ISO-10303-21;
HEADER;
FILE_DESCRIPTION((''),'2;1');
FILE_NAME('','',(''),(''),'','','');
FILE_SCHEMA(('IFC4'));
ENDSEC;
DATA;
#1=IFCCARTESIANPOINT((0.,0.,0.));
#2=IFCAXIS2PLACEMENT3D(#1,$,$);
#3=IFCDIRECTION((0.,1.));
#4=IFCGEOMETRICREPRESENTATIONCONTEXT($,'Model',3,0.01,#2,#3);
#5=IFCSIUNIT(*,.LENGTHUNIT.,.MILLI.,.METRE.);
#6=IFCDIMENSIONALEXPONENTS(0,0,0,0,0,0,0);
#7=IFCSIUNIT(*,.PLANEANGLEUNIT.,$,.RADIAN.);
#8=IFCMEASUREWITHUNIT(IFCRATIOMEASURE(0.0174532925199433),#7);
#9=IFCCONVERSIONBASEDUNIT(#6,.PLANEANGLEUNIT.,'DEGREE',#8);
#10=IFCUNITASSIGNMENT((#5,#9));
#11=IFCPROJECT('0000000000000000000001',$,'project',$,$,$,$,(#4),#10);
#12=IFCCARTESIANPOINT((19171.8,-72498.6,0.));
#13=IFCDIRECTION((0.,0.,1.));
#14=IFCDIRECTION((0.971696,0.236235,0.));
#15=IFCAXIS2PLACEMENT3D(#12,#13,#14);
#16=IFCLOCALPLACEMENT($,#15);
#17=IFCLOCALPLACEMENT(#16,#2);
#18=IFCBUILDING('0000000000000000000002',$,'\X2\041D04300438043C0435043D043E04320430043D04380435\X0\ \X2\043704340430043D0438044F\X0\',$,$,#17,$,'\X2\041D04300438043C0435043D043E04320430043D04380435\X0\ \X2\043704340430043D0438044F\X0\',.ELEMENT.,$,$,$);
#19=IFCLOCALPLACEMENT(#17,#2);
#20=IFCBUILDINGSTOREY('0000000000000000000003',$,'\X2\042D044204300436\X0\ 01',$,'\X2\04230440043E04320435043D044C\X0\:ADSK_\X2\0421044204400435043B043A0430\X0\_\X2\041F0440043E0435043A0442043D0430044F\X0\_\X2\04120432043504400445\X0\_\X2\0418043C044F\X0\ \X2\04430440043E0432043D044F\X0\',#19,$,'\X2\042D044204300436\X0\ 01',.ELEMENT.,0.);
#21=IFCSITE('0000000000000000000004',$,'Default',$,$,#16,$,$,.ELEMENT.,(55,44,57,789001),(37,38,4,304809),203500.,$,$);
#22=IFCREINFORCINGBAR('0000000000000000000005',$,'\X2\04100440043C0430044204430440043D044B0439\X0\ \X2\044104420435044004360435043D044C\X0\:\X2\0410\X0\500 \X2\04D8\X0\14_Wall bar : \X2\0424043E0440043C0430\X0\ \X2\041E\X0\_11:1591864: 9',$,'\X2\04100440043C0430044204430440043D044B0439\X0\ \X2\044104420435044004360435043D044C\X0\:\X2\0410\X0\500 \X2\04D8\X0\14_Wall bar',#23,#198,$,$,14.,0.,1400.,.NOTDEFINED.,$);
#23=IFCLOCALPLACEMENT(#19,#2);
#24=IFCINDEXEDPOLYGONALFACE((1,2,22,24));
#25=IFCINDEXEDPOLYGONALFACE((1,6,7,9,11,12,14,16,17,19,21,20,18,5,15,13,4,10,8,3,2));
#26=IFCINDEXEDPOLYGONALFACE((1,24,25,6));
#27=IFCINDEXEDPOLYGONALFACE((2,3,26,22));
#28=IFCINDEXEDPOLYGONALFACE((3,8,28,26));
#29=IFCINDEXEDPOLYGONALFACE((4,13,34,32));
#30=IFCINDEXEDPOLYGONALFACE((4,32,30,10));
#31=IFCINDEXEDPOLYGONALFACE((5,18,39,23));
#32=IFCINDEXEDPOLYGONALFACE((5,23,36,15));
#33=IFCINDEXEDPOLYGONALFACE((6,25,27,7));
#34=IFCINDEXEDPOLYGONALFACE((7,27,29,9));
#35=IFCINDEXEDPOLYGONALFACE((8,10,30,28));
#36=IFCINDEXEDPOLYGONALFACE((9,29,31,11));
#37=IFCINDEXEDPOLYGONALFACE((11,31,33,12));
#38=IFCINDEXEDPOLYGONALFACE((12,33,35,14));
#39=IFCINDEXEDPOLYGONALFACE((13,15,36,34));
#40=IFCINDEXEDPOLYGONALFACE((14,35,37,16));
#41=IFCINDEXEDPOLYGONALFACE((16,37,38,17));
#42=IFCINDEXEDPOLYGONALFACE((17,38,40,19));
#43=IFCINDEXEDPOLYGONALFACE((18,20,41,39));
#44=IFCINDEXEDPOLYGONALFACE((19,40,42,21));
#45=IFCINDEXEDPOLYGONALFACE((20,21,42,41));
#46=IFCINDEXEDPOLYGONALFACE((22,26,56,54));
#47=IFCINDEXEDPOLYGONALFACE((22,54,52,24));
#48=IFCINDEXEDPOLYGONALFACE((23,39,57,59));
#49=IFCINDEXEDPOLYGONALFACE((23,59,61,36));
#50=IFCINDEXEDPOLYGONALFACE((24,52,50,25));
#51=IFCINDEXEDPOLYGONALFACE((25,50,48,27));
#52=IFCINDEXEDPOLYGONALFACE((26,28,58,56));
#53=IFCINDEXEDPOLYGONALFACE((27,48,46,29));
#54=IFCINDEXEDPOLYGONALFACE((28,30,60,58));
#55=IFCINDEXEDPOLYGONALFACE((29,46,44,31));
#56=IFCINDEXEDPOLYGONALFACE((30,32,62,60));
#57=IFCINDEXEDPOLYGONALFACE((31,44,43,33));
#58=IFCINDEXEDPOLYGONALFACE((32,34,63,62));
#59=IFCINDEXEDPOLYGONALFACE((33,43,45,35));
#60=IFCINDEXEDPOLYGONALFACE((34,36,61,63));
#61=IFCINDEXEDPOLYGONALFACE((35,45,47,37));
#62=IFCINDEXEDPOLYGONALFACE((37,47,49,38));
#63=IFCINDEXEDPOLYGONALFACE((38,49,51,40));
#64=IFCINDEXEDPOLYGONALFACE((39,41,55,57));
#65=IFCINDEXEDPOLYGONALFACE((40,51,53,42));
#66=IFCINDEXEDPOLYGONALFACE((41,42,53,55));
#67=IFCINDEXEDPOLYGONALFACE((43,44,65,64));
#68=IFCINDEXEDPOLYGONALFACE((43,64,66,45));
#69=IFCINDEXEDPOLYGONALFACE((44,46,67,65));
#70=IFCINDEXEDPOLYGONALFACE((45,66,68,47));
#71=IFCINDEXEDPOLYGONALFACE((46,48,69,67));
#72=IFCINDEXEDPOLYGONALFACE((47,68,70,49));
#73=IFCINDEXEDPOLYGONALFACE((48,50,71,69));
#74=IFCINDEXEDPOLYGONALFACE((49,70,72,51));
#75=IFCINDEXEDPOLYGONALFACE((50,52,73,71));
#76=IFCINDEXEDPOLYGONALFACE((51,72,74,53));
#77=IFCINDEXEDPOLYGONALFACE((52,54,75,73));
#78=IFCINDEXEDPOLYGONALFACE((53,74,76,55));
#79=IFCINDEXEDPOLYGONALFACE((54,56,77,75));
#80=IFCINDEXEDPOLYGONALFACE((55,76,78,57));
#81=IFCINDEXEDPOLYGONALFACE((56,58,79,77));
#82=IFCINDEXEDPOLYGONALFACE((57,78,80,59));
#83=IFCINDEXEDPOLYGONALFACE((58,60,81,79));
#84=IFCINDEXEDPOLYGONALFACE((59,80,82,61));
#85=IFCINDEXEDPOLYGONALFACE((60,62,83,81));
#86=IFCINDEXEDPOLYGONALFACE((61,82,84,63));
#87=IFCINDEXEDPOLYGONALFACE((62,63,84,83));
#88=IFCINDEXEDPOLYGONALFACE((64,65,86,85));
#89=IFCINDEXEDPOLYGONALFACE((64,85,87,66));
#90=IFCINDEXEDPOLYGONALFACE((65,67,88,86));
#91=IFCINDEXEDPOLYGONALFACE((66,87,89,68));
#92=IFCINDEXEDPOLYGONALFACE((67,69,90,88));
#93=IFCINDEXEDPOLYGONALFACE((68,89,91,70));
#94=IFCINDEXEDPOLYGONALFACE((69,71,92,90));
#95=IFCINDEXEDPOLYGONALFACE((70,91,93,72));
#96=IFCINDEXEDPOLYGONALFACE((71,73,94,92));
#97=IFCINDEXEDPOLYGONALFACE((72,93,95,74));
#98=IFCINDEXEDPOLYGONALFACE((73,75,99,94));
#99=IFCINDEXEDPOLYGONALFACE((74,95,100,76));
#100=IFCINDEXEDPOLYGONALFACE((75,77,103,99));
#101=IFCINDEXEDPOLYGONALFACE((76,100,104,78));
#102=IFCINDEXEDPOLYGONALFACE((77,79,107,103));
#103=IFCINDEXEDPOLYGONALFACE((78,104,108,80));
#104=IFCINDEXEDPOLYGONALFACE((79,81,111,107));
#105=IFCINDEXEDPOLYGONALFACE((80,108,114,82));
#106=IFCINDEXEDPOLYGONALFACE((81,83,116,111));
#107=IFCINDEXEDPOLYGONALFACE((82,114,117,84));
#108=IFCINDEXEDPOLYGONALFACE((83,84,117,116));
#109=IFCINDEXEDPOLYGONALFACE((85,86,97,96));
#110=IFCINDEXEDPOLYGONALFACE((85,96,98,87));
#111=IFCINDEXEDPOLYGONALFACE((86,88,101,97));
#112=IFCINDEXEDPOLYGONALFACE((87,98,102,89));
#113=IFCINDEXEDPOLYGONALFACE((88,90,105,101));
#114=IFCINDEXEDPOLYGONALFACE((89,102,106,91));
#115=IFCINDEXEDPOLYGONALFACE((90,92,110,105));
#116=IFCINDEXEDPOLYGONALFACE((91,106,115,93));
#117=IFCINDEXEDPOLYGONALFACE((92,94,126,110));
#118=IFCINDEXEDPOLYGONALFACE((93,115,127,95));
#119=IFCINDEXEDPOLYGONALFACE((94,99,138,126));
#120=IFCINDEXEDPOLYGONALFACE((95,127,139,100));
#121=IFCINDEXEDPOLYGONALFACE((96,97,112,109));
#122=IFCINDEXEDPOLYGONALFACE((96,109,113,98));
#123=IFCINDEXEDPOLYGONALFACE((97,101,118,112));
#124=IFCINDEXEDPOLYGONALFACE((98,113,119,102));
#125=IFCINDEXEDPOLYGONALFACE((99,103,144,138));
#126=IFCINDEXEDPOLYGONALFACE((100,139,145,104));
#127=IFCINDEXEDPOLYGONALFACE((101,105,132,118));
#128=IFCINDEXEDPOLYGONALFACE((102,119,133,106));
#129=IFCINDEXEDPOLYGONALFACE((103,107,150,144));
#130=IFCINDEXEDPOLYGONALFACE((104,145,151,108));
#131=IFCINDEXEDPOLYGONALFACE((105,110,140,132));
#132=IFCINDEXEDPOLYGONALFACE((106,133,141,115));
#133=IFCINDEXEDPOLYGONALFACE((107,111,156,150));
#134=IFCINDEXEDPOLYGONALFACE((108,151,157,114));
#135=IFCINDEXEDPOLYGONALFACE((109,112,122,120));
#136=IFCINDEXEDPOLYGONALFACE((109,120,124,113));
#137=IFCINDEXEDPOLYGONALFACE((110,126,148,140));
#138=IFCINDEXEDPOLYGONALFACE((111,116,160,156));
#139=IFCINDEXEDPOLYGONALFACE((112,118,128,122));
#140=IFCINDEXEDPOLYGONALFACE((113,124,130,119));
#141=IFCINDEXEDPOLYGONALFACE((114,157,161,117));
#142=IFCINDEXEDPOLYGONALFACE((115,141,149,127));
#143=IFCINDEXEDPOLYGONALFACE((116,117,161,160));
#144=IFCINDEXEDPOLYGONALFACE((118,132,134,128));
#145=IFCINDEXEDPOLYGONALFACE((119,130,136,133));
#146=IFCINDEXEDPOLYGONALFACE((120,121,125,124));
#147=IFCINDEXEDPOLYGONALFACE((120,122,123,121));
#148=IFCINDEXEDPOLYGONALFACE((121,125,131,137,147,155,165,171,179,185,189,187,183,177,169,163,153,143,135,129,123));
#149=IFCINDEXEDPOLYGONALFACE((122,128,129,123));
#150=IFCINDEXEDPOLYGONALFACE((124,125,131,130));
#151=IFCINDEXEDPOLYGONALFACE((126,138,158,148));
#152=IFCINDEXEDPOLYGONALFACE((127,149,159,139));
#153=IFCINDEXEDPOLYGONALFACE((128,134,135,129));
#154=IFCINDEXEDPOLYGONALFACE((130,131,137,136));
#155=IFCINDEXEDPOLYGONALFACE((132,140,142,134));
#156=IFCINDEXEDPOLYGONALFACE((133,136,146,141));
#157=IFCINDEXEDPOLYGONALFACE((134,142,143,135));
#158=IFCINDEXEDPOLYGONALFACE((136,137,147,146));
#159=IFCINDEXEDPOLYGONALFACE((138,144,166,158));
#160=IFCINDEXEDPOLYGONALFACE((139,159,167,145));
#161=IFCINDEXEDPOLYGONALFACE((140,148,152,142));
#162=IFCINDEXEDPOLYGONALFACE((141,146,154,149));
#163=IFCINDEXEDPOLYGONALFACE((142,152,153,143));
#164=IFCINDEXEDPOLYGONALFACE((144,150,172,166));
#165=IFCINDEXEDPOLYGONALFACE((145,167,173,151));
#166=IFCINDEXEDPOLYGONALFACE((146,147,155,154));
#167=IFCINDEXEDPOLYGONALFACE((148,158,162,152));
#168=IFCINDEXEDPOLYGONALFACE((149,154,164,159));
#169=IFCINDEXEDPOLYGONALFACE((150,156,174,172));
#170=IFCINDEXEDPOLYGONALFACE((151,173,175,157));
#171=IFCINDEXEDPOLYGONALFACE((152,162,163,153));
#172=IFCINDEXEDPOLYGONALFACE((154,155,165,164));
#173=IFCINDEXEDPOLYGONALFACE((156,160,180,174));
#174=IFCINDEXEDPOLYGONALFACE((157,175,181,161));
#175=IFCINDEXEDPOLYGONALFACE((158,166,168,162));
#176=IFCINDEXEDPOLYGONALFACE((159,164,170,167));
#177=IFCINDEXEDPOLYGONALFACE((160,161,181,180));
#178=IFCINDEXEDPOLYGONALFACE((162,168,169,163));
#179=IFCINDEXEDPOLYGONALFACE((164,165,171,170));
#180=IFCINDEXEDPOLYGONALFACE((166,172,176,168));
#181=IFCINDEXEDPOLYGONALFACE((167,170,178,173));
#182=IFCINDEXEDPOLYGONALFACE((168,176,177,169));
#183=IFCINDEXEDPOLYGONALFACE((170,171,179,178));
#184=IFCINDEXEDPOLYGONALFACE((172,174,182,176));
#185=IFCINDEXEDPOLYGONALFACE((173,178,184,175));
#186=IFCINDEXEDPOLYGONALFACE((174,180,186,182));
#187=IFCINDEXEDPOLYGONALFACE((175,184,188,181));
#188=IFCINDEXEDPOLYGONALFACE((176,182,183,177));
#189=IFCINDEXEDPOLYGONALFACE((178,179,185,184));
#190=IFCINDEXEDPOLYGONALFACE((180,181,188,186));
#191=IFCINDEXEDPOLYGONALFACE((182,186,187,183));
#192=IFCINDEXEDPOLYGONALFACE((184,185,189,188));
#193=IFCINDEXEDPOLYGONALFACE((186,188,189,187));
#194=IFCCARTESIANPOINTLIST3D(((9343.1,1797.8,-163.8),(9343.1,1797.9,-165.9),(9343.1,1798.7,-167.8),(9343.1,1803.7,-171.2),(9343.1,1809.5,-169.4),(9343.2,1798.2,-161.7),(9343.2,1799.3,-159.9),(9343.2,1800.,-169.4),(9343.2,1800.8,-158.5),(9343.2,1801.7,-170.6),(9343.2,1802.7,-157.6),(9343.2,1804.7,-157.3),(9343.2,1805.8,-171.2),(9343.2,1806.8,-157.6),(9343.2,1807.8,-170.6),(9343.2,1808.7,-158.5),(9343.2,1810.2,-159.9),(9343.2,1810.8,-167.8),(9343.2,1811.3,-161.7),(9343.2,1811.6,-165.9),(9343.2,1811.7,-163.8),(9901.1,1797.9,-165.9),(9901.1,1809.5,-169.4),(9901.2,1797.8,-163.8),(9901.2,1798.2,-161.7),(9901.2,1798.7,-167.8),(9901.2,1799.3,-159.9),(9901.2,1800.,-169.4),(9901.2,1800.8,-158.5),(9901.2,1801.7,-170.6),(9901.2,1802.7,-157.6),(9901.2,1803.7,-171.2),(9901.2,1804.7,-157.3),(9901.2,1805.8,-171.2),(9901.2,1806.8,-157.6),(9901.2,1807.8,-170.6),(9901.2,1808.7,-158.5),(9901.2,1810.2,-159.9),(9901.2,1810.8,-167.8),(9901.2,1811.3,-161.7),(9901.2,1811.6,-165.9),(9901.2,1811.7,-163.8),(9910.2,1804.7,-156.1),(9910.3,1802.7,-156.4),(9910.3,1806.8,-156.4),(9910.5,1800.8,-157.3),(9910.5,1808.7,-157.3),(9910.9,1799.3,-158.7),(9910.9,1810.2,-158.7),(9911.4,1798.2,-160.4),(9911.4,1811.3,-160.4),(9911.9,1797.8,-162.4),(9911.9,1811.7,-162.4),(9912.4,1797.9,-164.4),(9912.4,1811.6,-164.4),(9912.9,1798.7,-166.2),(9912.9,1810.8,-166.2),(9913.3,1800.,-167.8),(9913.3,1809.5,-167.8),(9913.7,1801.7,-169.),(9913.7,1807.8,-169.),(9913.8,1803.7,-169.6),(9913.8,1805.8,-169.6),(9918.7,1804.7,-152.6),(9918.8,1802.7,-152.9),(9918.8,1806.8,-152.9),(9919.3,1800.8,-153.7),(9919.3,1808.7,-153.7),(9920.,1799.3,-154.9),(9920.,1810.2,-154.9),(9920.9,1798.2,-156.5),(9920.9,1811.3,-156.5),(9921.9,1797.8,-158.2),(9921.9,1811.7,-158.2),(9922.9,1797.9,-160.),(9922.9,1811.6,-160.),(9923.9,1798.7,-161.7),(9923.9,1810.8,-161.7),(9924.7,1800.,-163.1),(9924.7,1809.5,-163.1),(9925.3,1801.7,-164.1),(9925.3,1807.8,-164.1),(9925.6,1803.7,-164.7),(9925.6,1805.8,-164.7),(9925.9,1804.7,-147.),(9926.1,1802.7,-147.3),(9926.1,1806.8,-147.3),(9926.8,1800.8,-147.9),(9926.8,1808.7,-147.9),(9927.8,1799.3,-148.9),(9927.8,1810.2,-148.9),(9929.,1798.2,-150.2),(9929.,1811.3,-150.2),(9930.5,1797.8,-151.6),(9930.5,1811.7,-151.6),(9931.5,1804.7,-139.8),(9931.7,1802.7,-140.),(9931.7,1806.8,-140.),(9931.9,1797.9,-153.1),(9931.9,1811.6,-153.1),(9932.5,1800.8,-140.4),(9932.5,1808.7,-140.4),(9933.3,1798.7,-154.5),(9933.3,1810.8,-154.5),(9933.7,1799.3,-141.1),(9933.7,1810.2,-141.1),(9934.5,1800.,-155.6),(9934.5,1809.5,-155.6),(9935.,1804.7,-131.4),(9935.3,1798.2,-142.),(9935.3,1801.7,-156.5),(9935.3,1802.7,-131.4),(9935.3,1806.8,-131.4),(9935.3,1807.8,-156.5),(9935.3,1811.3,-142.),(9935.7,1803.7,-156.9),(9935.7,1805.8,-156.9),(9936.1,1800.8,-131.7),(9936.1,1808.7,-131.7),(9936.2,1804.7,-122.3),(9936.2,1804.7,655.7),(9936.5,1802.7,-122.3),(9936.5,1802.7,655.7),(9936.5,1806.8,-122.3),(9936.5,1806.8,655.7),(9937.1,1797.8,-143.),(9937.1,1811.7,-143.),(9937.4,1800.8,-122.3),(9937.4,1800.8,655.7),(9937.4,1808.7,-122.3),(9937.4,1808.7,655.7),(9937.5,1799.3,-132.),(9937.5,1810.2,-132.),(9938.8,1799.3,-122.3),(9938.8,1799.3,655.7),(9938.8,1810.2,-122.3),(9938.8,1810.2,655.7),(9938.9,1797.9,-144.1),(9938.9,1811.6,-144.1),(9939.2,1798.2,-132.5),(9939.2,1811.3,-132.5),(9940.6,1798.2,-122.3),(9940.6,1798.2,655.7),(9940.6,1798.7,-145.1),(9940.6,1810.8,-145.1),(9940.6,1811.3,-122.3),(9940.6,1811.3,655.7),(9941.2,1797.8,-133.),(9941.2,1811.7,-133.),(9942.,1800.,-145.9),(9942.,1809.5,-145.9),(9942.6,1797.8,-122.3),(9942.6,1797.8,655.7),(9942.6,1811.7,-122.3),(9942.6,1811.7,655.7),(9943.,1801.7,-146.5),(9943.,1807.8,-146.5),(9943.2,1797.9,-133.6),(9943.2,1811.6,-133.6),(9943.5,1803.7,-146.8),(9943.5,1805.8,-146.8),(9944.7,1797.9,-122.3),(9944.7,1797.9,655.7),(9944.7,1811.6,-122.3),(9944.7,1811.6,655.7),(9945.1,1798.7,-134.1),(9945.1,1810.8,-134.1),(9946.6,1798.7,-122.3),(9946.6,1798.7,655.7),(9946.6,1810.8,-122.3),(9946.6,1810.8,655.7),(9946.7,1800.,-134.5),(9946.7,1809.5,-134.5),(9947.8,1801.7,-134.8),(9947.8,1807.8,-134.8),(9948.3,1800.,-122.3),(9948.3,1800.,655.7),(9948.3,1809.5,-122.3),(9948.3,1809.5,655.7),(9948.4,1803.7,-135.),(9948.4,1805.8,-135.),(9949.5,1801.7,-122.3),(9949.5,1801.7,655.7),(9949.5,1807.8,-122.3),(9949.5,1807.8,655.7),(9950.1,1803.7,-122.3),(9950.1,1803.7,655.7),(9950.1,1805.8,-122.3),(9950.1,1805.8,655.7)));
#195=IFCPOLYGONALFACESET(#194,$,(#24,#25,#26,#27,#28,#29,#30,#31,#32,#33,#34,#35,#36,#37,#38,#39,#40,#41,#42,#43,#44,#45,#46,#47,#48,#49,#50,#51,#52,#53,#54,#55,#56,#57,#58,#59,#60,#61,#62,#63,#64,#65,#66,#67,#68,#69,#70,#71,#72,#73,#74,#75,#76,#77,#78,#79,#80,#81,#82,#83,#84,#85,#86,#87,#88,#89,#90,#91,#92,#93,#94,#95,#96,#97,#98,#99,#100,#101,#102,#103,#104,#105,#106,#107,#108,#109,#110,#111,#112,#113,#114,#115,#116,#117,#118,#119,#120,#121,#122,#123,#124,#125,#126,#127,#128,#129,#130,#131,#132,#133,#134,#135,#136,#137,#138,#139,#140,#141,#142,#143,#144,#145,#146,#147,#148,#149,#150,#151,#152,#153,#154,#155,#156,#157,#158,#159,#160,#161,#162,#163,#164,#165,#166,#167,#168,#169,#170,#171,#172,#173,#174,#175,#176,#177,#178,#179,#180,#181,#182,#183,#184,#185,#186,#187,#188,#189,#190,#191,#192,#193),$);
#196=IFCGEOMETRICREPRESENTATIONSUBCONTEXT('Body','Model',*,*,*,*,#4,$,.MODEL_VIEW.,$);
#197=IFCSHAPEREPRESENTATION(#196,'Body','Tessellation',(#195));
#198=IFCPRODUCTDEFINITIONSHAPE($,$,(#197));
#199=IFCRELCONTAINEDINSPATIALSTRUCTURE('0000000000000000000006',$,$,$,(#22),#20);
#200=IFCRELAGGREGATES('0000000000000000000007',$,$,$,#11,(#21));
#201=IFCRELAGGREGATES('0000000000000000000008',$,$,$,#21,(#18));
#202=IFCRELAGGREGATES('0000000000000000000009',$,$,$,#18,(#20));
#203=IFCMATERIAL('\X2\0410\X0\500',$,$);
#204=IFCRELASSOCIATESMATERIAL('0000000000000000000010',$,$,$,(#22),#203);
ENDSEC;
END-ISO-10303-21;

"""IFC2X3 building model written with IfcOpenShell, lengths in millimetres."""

from ifc_helpers import new_model, entity, si_unit, converted_unit, direction, frame, origin, place, context, subcontext, project, spatial, material, element, save


model = new_model("IFC2X3")

# Units and contexts
model_context = context("Model", 3, precision=0.01, world=origin(), true_north=direction((0.0, 1.0)))
body_context = subcontext(model_context, "Body", "Model", "MODEL_VIEW")
ifc_project = project(units=[si_unit("LENGTHUNIT", "METRE", prefix="MILLI"), converted_unit("PLANEANGLEUNIT", "DEGREE", entity("IfcRatioMeasure", 0.0174532925199433), si_unit("PLANEANGLEUNIT", "RADIAN"), dimensions=[0, 0, 0, 0, 0, 0, 0])], contexts=[model_context])

# Site, building, storey
site_placement = place(None, frame((19171.8, -72498.6, 0.0), z_axis=(0.0, 0.0, 1.0), x_axis=(0.971696, 0.236235, 0.0)))
site = spatial("IfcSite", under=ifc_project, at=site_placement, Name="Default", CompositionType="ELEMENT", RefLatitude=(55, 44, 57, 789001), RefLongitude=(37, 38, 4, 304809), RefElevation=203500.0)
building_placement = place(site_placement, origin())
building = spatial("IfcBuilding", under=site, at=building_placement, Name="Наименование здания", LongName="Наименование здания", CompositionType="ELEMENT")
storey_placement = place(building_placement, origin())
storey = spatial("IfcBuildingStorey", under=building, at=storey_placement, Name="Этаж 01", ObjectType="Уровень:ADSK_Стрелка_Проектная_Вверх_Имя уровня", LongName="Этаж 01", CompositionType="ELEMENT", Elevation=0.0)

# Reinforcing bar
ifc_material = material(Name="А500")
placement = place(storey_placement, origin())
element("IfcReinforcingBar", 1, at=placement, inside=storey, material=ifc_material, Name="Арматурный стержень:А500 Ә14_Wall bar : Форма О_11:1591864: 9", ObjectType="Арматурный стержень:А500 Ә14_Wall bar", BarLength=1400.0, BarRole="NOTDEFINED", CrossSectionArea=0.0, NominalDiameter=14.0, context=body_context, shape_type="AdvancedSweptSolid", body=[
    entity("IfcSweptDiskSolid", entity("IfcCompositeCurve", [entity("IfcCompositeCurveSegment", "CONTINUOUS", True, entity("IfcPolyline", [entity("IfcCartesianPoint", [9943.1, 1804.7, 655.7]), entity("IfcCartesianPoint", [9943.1, 1804.7, -122.3])])), entity("IfcCompositeCurveSegment", "CONTINUOUS", True, entity("IfcTrimmedCurve", entity("IfcCircle", entity("IfcAxis2Placement3D", entity("IfcCartesianPoint", [9901.1, 1804.7, -122.3]), entity("IfcDirection", [0.0, 1.0, 0.0]), entity("IfcDirection", [0.0, 0.0, -1.0])), 42.0), [entity("IfcParameterValue", 270.0)], [entity("IfcParameterValue", 360.0)], True, "PARAMETER")), entity("IfcCompositeCurveSegment", "CONTINUOUS", True, entity("IfcPolyline", [entity("IfcCartesianPoint", [9901.1, 1804.7, -164.3]), entity("IfcCartesianPoint", [9343.1, 1804.7, -164.3])]))], False), 7.0, None, 0.0, 92.0),
])

save(model, "model.ifc")
